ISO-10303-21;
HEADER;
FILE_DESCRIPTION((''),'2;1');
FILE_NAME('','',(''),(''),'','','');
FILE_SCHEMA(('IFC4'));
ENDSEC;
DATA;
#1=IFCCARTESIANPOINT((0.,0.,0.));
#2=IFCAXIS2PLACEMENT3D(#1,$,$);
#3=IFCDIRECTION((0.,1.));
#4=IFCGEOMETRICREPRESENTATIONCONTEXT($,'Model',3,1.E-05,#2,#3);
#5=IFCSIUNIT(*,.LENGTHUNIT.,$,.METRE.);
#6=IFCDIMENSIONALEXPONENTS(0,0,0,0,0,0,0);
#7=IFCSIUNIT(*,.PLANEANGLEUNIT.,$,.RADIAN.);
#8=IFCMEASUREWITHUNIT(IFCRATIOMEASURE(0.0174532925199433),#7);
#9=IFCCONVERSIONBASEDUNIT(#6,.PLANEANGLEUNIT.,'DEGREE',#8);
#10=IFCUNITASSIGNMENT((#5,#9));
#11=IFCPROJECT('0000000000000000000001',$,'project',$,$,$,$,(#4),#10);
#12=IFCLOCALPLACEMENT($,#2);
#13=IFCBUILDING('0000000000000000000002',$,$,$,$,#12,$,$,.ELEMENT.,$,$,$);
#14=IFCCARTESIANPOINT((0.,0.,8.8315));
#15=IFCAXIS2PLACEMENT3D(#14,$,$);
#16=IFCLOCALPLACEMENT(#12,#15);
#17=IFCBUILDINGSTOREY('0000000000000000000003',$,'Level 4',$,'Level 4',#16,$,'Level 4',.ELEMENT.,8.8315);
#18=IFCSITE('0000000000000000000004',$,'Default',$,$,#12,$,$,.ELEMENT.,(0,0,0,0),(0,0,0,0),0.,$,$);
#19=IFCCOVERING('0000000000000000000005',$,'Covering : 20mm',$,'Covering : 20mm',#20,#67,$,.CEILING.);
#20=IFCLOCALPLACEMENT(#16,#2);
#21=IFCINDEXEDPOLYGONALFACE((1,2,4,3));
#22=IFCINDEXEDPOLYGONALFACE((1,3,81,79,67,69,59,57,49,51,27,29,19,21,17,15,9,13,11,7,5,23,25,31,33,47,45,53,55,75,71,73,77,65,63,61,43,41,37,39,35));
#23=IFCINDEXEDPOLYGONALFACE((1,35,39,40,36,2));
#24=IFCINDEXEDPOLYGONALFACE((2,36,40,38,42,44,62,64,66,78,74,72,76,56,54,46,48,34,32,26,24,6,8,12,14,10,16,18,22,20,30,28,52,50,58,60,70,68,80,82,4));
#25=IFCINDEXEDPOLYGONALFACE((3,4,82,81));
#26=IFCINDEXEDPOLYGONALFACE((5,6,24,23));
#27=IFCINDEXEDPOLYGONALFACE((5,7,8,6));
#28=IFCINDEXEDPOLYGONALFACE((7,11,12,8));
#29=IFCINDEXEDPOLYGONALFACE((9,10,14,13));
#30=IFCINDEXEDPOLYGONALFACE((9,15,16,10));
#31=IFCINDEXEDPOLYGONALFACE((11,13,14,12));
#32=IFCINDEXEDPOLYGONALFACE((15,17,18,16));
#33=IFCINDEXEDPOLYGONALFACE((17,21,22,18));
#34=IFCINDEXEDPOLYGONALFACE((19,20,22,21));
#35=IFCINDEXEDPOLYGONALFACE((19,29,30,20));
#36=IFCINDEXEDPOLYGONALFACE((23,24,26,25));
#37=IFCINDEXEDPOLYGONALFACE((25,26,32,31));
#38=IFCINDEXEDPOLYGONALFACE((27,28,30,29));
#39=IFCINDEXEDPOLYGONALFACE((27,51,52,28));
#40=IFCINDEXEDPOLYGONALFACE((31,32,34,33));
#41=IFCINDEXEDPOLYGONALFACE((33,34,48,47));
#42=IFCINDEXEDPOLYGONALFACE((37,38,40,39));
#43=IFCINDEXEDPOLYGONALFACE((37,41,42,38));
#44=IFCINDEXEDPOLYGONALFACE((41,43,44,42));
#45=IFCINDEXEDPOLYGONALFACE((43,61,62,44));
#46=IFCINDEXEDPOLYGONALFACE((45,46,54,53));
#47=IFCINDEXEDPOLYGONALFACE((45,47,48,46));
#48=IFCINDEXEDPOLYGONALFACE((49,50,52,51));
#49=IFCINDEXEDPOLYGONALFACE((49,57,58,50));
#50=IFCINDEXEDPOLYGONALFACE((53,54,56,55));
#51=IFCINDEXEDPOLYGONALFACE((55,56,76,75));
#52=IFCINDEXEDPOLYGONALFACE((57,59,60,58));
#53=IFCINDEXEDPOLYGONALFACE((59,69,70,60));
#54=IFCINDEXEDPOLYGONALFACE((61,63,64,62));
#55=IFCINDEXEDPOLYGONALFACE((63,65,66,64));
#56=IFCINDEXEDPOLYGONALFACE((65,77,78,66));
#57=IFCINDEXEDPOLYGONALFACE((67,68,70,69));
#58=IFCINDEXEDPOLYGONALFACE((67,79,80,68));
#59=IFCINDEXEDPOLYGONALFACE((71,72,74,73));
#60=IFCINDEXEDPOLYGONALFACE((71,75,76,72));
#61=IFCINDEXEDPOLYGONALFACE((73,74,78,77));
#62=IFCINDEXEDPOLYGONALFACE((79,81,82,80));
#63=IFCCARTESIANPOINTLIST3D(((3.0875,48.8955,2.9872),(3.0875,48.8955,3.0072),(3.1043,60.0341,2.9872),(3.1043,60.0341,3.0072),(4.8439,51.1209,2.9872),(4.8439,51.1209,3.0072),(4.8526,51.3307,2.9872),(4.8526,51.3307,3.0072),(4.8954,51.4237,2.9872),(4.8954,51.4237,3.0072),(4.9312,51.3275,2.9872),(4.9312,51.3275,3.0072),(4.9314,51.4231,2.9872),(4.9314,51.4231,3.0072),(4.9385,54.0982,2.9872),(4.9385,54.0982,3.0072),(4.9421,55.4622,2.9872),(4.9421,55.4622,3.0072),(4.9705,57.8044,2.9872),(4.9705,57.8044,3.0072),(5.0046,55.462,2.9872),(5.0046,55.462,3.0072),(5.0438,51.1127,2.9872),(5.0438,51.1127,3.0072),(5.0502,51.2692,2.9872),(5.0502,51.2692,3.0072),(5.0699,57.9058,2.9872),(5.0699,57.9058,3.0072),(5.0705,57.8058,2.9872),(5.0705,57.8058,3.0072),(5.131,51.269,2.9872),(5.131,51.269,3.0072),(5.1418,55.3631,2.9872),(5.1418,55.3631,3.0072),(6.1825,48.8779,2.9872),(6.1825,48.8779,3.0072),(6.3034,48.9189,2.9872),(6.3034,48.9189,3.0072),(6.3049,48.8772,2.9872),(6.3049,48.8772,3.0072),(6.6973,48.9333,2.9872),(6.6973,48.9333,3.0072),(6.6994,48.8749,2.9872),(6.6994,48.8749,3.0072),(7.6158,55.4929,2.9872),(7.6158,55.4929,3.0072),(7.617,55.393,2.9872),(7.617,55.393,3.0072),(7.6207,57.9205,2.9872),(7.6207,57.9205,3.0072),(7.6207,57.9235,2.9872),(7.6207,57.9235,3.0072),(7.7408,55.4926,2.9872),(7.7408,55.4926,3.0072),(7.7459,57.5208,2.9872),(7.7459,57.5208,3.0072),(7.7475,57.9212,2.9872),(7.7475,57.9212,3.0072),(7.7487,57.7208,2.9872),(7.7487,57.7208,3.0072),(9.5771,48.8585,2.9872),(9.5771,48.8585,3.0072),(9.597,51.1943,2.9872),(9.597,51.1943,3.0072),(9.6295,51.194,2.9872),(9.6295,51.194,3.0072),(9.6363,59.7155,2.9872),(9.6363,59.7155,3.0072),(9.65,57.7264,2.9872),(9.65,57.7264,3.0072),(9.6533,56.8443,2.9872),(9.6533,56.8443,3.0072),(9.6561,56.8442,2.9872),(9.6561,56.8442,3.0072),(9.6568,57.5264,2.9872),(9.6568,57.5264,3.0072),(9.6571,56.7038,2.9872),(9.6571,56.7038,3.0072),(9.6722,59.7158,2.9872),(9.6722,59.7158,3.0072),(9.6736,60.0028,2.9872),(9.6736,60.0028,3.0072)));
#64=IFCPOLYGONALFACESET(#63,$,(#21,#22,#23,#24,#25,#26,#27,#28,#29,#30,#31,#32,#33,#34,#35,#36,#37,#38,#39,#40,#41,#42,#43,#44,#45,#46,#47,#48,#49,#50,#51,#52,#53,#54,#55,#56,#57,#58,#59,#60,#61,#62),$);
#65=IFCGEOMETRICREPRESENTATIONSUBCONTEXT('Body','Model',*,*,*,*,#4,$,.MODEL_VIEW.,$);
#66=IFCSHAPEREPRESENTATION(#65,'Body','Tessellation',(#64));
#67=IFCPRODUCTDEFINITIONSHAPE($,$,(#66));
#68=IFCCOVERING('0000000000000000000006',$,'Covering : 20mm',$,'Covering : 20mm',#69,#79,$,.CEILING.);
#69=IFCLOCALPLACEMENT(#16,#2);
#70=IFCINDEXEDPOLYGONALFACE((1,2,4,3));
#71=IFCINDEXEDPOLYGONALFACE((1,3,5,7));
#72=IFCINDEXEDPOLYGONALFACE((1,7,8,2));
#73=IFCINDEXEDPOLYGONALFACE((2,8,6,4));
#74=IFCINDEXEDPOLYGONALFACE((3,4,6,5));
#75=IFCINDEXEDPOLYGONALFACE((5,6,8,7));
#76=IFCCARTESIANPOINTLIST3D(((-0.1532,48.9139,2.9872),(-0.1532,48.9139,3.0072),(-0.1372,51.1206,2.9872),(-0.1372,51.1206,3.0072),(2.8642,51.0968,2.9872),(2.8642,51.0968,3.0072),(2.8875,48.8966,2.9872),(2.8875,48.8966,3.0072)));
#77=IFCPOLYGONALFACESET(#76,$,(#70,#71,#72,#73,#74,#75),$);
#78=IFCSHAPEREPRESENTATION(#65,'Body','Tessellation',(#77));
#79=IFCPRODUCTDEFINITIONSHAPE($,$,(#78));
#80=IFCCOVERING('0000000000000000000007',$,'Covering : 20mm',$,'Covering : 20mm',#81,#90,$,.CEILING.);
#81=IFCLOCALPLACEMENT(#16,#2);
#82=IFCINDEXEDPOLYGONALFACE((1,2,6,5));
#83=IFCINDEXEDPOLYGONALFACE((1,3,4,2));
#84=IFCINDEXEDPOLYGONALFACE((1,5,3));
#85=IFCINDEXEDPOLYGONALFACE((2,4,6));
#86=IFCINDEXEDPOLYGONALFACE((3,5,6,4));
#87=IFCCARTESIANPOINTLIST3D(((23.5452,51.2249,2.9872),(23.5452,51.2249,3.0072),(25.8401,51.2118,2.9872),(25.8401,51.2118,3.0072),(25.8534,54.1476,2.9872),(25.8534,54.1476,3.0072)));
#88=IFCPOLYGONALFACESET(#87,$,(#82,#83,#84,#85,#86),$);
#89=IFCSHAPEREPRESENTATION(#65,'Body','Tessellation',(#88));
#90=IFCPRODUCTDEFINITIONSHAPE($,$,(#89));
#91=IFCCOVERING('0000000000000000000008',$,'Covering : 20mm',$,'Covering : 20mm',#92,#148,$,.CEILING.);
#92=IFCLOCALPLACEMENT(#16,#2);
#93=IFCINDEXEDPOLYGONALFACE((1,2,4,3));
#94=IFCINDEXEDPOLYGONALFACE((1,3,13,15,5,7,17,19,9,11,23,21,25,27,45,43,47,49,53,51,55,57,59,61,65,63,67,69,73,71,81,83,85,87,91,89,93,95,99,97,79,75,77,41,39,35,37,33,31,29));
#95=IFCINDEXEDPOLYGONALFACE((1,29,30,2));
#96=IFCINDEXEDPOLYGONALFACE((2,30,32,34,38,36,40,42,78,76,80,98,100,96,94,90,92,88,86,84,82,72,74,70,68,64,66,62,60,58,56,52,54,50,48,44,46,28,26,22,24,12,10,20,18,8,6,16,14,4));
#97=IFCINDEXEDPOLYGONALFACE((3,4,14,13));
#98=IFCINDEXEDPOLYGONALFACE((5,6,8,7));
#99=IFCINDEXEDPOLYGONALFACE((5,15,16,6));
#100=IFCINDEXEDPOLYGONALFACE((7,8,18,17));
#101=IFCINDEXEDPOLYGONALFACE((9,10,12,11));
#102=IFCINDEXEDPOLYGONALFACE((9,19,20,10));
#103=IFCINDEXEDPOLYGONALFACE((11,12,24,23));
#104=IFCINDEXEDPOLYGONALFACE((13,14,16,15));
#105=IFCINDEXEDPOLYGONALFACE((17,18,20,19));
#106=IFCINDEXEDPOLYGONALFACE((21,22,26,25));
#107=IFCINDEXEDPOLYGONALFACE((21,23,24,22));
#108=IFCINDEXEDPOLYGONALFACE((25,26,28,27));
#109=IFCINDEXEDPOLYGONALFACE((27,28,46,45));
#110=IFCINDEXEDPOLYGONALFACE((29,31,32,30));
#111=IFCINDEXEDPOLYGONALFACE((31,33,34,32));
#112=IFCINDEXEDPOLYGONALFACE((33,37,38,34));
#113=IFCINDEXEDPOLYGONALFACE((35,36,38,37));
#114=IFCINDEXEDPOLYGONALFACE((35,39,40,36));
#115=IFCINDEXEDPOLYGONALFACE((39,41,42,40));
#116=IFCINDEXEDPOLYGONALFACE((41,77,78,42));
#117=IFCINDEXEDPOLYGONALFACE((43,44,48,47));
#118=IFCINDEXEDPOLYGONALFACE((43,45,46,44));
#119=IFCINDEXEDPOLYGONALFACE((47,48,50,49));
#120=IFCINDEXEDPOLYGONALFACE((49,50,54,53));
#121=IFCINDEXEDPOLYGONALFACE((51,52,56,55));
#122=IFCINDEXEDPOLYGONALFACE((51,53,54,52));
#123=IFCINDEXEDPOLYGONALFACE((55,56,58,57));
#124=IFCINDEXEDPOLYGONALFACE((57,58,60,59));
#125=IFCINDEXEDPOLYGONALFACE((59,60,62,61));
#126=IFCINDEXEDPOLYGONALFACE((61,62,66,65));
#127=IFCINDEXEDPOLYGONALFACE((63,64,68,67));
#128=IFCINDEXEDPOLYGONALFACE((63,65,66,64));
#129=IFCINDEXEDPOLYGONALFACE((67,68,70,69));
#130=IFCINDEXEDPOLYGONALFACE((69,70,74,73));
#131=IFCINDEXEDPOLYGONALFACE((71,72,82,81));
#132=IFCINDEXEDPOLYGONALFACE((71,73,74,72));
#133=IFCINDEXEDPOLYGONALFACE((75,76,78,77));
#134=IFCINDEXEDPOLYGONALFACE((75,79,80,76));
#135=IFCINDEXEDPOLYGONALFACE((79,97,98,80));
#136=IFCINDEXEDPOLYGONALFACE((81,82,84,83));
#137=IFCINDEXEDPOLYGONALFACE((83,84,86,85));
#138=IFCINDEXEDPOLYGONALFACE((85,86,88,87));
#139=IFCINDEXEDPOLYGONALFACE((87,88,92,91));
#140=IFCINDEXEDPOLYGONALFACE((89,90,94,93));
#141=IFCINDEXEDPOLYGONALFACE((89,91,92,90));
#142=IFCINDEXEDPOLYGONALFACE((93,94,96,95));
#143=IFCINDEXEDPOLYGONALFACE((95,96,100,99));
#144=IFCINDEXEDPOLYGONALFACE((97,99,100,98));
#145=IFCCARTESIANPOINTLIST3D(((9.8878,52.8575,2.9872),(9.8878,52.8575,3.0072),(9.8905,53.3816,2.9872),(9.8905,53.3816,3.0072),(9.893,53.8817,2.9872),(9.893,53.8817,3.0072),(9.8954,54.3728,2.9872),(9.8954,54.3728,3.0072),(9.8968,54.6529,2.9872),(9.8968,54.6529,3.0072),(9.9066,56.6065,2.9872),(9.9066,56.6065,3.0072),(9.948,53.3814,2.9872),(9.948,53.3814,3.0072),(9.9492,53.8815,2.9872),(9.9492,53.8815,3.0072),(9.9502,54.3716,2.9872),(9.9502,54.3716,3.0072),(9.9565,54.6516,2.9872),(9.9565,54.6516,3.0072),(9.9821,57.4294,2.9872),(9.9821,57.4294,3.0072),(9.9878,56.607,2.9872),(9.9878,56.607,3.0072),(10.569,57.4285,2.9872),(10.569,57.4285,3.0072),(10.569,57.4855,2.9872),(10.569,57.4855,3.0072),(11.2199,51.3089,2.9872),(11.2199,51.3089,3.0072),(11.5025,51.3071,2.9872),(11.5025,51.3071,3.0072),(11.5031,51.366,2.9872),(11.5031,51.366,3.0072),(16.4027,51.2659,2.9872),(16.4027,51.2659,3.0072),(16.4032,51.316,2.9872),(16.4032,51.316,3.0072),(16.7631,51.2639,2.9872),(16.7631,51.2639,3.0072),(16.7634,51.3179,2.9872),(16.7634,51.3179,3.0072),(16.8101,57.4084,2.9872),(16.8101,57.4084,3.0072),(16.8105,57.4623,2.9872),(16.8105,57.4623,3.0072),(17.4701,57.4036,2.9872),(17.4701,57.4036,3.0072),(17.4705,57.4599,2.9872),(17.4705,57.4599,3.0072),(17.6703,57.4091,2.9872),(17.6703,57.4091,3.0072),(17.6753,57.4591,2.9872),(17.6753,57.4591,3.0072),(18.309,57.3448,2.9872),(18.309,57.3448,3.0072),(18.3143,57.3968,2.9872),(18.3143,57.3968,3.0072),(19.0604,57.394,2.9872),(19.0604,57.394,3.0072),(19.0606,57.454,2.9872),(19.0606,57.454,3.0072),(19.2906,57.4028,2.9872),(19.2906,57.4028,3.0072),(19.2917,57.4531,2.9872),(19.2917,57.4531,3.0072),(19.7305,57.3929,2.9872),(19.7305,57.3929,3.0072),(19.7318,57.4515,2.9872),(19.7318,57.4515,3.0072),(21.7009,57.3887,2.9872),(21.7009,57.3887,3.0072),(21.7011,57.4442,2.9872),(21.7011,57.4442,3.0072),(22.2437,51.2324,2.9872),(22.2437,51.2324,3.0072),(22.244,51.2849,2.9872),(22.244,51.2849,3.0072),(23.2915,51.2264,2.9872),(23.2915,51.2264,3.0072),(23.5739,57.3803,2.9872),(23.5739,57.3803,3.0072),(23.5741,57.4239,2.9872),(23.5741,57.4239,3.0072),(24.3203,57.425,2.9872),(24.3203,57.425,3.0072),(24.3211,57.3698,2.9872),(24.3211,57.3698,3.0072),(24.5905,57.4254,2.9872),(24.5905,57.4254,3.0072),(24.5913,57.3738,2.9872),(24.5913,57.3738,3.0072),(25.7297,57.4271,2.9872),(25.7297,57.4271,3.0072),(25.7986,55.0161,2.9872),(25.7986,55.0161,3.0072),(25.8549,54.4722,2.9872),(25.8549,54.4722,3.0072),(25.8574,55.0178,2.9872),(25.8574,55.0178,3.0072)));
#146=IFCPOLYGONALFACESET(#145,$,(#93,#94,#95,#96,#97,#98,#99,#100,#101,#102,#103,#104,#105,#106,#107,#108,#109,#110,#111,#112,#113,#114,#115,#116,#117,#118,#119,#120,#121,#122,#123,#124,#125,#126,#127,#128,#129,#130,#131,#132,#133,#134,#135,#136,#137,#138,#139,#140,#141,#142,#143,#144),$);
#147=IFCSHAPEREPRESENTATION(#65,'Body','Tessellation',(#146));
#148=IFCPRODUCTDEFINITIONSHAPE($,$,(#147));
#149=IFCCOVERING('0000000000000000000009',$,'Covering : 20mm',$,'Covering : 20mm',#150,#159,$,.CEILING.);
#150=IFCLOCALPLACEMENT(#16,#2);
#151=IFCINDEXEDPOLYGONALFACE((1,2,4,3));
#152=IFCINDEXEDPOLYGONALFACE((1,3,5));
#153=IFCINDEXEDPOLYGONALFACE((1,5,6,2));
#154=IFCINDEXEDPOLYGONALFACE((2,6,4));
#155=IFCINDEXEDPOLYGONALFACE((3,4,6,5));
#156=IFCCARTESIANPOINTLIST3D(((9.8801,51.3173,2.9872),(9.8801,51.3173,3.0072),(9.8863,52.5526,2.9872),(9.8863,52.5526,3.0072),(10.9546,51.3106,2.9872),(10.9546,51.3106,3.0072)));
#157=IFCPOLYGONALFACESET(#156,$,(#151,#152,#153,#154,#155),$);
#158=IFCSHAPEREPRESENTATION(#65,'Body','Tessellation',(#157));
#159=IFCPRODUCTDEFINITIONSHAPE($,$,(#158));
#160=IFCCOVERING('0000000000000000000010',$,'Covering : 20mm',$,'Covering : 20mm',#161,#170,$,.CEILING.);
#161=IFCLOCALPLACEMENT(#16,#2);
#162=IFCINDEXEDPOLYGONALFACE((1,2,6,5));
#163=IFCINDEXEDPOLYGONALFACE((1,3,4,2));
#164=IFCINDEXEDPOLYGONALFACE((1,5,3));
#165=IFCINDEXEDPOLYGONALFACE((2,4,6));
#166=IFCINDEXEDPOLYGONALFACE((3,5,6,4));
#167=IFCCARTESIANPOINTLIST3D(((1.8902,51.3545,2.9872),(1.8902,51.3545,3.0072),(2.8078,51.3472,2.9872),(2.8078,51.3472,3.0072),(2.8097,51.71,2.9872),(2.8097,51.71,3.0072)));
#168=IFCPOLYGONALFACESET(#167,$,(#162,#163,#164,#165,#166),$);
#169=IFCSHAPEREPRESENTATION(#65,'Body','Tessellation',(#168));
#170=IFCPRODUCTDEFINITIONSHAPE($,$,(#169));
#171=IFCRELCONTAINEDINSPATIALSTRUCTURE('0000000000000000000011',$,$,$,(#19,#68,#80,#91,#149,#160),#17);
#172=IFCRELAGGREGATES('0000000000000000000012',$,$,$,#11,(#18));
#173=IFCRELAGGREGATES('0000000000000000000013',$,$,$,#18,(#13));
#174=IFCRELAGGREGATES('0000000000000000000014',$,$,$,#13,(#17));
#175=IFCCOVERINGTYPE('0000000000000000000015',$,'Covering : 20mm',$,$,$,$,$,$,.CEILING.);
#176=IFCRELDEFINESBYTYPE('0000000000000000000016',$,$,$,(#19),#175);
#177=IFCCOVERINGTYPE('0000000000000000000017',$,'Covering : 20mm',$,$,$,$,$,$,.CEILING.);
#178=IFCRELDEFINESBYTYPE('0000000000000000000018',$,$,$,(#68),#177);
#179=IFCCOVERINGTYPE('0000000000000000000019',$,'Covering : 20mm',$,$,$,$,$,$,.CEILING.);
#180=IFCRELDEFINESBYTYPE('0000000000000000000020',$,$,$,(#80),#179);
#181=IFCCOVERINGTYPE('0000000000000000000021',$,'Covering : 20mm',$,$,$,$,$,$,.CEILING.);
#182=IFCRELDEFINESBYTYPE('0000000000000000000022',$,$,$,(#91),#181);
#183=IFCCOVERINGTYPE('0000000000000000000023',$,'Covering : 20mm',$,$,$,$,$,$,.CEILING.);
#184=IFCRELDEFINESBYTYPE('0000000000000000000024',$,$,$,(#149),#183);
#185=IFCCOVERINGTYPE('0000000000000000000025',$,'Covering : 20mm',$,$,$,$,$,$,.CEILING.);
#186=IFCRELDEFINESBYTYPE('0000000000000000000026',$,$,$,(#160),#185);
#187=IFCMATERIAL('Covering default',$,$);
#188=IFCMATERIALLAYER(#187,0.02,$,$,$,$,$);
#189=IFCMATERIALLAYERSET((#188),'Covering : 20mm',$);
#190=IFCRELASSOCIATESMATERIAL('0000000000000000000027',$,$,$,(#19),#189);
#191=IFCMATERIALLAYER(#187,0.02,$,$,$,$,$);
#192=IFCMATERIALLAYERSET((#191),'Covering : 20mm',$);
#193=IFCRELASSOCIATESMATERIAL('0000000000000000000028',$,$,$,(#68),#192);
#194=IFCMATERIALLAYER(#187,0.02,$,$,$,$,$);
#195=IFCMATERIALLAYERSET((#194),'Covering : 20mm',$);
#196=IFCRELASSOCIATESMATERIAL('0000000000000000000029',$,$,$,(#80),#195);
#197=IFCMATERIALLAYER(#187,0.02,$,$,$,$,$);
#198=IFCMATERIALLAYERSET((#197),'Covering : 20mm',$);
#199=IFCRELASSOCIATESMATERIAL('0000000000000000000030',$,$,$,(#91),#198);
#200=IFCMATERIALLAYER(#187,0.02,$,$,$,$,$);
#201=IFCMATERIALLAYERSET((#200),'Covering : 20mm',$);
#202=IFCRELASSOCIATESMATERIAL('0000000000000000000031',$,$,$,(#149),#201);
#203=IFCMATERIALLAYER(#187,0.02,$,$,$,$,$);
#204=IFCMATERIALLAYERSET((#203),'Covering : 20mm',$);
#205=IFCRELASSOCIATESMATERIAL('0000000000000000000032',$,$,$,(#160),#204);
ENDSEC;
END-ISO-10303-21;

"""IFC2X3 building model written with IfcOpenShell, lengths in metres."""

from ifc_helpers import new_model, entity, si_unit, converted_unit, direction, frame, origin, origin_with_axes, place, context, subcontext, project, spatial, polyline, outline, extrude, material, layer, layer_set, layer_usage, type_object, element, save


model = new_model("IFC2X3")

# Units and contexts
model_context = context("Model", 3, precision=1e-05, world=origin(), true_north=direction((0.0, 1.0)))
body_context = subcontext(model_context, "Body", "Model", "MODEL_VIEW")
ifc_project = project(units=[si_unit("LENGTHUNIT", "METRE"), converted_unit("PLANEANGLEUNIT", "DEGREE", entity("IfcRatioMeasure", 0.0174532925199433), si_unit("PLANEANGLEUNIT", "RADIAN"), dimensions=[0, 0, 0, 0, 0, 0, 0])], contexts=[model_context])

# Site, building, storey
placement = place(None, origin())
site = spatial("IfcSite", under=ifc_project, at=placement, Name="Default", CompositionType="ELEMENT", RefLatitude=(0, 0, 0, 0), RefLongitude=(0, 0, 0, 0), RefElevation=0.0)
building = spatial("IfcBuilding", under=site, at=placement, CompositionType="ELEMENT")
storey_placement = place(placement, frame((0.0, 0.0, 8.8315)))
storey = spatial("IfcBuildingStorey", under=building, at=storey_placement, Name="Level 4", ObjectType="Level 4", LongName="Level 4", CompositionType="ELEMENT", Elevation=8.8315)

# Coverings
ifc_material_1 = material(Name="Covering default")
ifc_layer_1 = layer(ifc_material_1, 0.02)
ifc_layer_set_1 = layer_set([ifc_layer_1], Name="Covering : 20mm")
ifc_layer_usage_1 = layer_usage(ifc_layer_set_1, "AXIS3", "POSITIVE", 0.0)
covering_type_1 = type_object("IfcCoveringType", Name="Covering : 20mm", PredefinedType="CEILING")
covering_1_placement = place(placement, frame((0.0, 0.0, 11.8187)))
element("IfcCovering", 1, at=covering_1_placement, inside=storey, type_object=covering_type_1, material=ifc_layer_usage_1, Name="Covering : 20mm", ObjectType="Covering : 20mm", PredefinedType="CEILING", context=body_context, shape_type="SweptSolid", body=[
    extrude(outline(polyline([(3.1043, 60.0341), (9.6736, 60.0028), (9.6722, 59.7158), (9.6363, 59.7155), (9.65, 57.7264), (7.7487, 57.7208), (7.7475, 57.9212), (7.6207, 57.9205), (7.6207, 57.9235), (5.0699, 57.9058), (5.0705, 57.8058), (4.9705, 57.8044), (5.0046, 55.462), (4.9421, 55.4622), (4.9385, 54.0982), (4.8954, 51.4237), (4.9314, 51.4231), (4.9312, 51.3275), (4.8526, 51.3307), (4.8439, 51.1209), (5.0438, 51.1127), (5.0502, 51.2692), (5.131, 51.269), (5.1418, 55.3631), (7.617, 55.393), (7.6158, 55.4929), (7.7408, 55.4926), (7.7459, 57.5208), (9.6568, 57.5264), (9.6533, 56.8443), (9.6561, 56.8442), (9.6571, 56.7038), (9.6295, 51.194), (9.597, 51.1943), (9.5771, 48.8585), (6.6994, 48.8749), (6.6973, 48.9333), (6.3034, 48.9189), (6.3049, 48.8772), (6.1825, 48.8779), (6.1825, 48.8779), (3.0875, 48.8955), (3.1043, 60.0341)])), origin_with_axes(), (0.0, 0.0, 1.0), 0.02),
])
ifc_layer_2 = layer(ifc_material_1, 0.02)
ifc_layer_set_2 = layer_set([ifc_layer_2], Name="Covering : 20mm")
ifc_layer_usage_2 = layer_usage(ifc_layer_set_2, "AXIS3", "POSITIVE", 0.0)
covering_type_2 = type_object("IfcCoveringType", Name="Covering : 20mm", PredefinedType="CEILING")
covering_2_placement = place(placement, frame((0.0, 0.0, 11.8187)))
element("IfcCovering", 2, at=covering_2_placement, inside=storey, type_object=covering_type_2, material=ifc_layer_usage_2, Name="Covering : 20mm", ObjectType="Covering : 20mm", PredefinedType="CEILING", context=body_context, shape_type="SweptSolid", body=[
    extrude(outline(polyline([(-0.1372, 51.1206), (2.8642, 51.0968), (2.8875, 48.8966), (-0.1532, 48.9139), (-0.1372, 51.1206)])), origin_with_axes(), (0.0, 0.0, 1.0), 0.02),
])
ifc_layer_3 = layer(ifc_material_1, 0.02)
ifc_layer_set_3 = layer_set([ifc_layer_3], Name="Covering : 20mm")
ifc_layer_usage_3 = layer_usage(ifc_layer_set_3, "AXIS3", "POSITIVE", 0.0)
covering_type_3 = type_object("IfcCoveringType", Name="Covering : 20mm", PredefinedType="CEILING")
covering_3_placement = place(placement, frame((0.0, 0.0, 11.8187)))
element("IfcCovering", 3, at=covering_3_placement, inside=storey, type_object=covering_type_3, material=ifc_layer_usage_3, Name="Covering : 20mm", ObjectType="Covering : 20mm", PredefinedType="CEILING", context=body_context, shape_type="SweptSolid", body=[
    extrude(outline(polyline([(23.5452, 51.2249), (25.8534, 54.1476), (25.8401, 51.2118), (23.5452, 51.2249)])), origin_with_axes(), (0.0, 0.0, 1.0), 0.02),
])
ifc_layer_4 = layer(ifc_material_1, 0.02)
ifc_layer_set_4 = layer_set([ifc_layer_4], Name="Covering : 20mm")
ifc_layer_usage_4 = layer_usage(ifc_layer_set_4, "AXIS3", "POSITIVE", 0.0)
covering_type_4 = type_object("IfcCoveringType", Name="Covering : 20mm", PredefinedType="CEILING")
covering_4_placement = place(placement, frame((0.0, 0.0, 11.8187)))
element("IfcCovering", 4, at=covering_4_placement, inside=storey, type_object=covering_type_4, material=ifc_layer_usage_4, Name="Covering : 20mm", ObjectType="Covering : 20mm", PredefinedType="CEILING", context=body_context, shape_type="SweptSolid", body=[
    extrude(outline(polyline([(11.2199, 51.3089), (11.5025, 51.3071), (11.5031, 51.366), (16.4032, 51.316), (16.4027, 51.2659), (16.7631, 51.2639), (16.7634, 51.3179), (22.244, 51.2849), (22.2437, 51.2324), (23.2915, 51.2264), (25.8549, 54.4722), (25.8574, 55.0178), (25.7986, 55.0161), (25.7297, 57.4271), (24.5905, 57.4254), (24.5913, 57.3738), (24.3211, 57.3698), (24.3203, 57.425), (23.5741, 57.4239), (23.5739, 57.3803), (21.7009, 57.3887), (21.7011, 57.4442), (19.7318, 57.4515), (19.7305, 57.3929), (19.2906, 57.4028), (19.2917, 57.4531), (19.0606, 57.454), (19.0604, 57.394), (18.3143, 57.3968), (18.309, 57.3448), (17.6703, 57.4091), (17.6753, 57.4591), (17.4705, 57.4599), (17.4701, 57.4036), (16.8101, 57.4084), (16.8105, 57.4623), (10.569, 57.4855), (10.569, 57.4285), (9.9821, 57.4294), (9.9878, 56.607), (9.9066, 56.6065), (9.8968, 54.6529), (9.9565, 54.6516), (9.9502, 54.3716), (9.8954, 54.3728), (9.893, 53.8817), (9.9492, 53.8815), (9.948, 53.3814), (9.8905, 53.3816), (9.8878, 52.8575), (11.2199, 51.3089)])), origin_with_axes(), (0.0, 0.0, 1.0), 0.02),
])
ifc_layer_5 = layer(ifc_material_1, 0.02)
ifc_layer_set_5 = layer_set([ifc_layer_5], Name="Covering : 20mm")
ifc_layer_usage_5 = layer_usage(ifc_layer_set_5, "AXIS3", "POSITIVE", 0.0)
covering_type_5 = type_object("IfcCoveringType", Name="Covering : 20mm", PredefinedType="CEILING")
covering_5_placement = place(placement, frame((0.0, 0.0, 11.8187)))
element("IfcCovering", 5, at=covering_5_placement, inside=storey, type_object=covering_type_5, material=ifc_layer_usage_5, Name="Covering : 20mm", ObjectType="Covering : 20mm", PredefinedType="CEILING", context=body_context, shape_type="SweptSolid", body=[
    extrude(outline(polyline([(9.8863, 52.5526), (10.9546, 51.3106), (9.8801, 51.3173), (9.8863, 52.5526)])), origin_with_axes(), (0.0, 0.0, 1.0), 0.02),
])
ifc_layer_6 = layer(ifc_material_1, 0.02)
ifc_layer_set_6 = layer_set([ifc_layer_6], Name="Covering : 20mm")
ifc_layer_usage_6 = layer_usage(ifc_layer_set_6, "AXIS3", "POSITIVE", 0.0)
covering_type_6 = type_object("IfcCoveringType", Name="Covering : 20mm", PredefinedType="CEILING")
covering_6_placement = place(placement, frame((0.0, 0.0, 11.8187)))
element("IfcCovering", 6, at=covering_6_placement, inside=storey, type_object=covering_type_6, material=ifc_layer_usage_6, Name="Covering : 20mm", ObjectType="Covering : 20mm", PredefinedType="CEILING", context=body_context, shape_type="SweptSolid", body=[
    extrude(outline(polyline([(1.8902, 51.3545), (2.8097, 51.71), (2.8078, 51.3472), (1.8902, 51.3545)])), origin_with_axes(), (0.0, 0.0, 1.0), 0.02),
])

save(model, "model.ifc")
